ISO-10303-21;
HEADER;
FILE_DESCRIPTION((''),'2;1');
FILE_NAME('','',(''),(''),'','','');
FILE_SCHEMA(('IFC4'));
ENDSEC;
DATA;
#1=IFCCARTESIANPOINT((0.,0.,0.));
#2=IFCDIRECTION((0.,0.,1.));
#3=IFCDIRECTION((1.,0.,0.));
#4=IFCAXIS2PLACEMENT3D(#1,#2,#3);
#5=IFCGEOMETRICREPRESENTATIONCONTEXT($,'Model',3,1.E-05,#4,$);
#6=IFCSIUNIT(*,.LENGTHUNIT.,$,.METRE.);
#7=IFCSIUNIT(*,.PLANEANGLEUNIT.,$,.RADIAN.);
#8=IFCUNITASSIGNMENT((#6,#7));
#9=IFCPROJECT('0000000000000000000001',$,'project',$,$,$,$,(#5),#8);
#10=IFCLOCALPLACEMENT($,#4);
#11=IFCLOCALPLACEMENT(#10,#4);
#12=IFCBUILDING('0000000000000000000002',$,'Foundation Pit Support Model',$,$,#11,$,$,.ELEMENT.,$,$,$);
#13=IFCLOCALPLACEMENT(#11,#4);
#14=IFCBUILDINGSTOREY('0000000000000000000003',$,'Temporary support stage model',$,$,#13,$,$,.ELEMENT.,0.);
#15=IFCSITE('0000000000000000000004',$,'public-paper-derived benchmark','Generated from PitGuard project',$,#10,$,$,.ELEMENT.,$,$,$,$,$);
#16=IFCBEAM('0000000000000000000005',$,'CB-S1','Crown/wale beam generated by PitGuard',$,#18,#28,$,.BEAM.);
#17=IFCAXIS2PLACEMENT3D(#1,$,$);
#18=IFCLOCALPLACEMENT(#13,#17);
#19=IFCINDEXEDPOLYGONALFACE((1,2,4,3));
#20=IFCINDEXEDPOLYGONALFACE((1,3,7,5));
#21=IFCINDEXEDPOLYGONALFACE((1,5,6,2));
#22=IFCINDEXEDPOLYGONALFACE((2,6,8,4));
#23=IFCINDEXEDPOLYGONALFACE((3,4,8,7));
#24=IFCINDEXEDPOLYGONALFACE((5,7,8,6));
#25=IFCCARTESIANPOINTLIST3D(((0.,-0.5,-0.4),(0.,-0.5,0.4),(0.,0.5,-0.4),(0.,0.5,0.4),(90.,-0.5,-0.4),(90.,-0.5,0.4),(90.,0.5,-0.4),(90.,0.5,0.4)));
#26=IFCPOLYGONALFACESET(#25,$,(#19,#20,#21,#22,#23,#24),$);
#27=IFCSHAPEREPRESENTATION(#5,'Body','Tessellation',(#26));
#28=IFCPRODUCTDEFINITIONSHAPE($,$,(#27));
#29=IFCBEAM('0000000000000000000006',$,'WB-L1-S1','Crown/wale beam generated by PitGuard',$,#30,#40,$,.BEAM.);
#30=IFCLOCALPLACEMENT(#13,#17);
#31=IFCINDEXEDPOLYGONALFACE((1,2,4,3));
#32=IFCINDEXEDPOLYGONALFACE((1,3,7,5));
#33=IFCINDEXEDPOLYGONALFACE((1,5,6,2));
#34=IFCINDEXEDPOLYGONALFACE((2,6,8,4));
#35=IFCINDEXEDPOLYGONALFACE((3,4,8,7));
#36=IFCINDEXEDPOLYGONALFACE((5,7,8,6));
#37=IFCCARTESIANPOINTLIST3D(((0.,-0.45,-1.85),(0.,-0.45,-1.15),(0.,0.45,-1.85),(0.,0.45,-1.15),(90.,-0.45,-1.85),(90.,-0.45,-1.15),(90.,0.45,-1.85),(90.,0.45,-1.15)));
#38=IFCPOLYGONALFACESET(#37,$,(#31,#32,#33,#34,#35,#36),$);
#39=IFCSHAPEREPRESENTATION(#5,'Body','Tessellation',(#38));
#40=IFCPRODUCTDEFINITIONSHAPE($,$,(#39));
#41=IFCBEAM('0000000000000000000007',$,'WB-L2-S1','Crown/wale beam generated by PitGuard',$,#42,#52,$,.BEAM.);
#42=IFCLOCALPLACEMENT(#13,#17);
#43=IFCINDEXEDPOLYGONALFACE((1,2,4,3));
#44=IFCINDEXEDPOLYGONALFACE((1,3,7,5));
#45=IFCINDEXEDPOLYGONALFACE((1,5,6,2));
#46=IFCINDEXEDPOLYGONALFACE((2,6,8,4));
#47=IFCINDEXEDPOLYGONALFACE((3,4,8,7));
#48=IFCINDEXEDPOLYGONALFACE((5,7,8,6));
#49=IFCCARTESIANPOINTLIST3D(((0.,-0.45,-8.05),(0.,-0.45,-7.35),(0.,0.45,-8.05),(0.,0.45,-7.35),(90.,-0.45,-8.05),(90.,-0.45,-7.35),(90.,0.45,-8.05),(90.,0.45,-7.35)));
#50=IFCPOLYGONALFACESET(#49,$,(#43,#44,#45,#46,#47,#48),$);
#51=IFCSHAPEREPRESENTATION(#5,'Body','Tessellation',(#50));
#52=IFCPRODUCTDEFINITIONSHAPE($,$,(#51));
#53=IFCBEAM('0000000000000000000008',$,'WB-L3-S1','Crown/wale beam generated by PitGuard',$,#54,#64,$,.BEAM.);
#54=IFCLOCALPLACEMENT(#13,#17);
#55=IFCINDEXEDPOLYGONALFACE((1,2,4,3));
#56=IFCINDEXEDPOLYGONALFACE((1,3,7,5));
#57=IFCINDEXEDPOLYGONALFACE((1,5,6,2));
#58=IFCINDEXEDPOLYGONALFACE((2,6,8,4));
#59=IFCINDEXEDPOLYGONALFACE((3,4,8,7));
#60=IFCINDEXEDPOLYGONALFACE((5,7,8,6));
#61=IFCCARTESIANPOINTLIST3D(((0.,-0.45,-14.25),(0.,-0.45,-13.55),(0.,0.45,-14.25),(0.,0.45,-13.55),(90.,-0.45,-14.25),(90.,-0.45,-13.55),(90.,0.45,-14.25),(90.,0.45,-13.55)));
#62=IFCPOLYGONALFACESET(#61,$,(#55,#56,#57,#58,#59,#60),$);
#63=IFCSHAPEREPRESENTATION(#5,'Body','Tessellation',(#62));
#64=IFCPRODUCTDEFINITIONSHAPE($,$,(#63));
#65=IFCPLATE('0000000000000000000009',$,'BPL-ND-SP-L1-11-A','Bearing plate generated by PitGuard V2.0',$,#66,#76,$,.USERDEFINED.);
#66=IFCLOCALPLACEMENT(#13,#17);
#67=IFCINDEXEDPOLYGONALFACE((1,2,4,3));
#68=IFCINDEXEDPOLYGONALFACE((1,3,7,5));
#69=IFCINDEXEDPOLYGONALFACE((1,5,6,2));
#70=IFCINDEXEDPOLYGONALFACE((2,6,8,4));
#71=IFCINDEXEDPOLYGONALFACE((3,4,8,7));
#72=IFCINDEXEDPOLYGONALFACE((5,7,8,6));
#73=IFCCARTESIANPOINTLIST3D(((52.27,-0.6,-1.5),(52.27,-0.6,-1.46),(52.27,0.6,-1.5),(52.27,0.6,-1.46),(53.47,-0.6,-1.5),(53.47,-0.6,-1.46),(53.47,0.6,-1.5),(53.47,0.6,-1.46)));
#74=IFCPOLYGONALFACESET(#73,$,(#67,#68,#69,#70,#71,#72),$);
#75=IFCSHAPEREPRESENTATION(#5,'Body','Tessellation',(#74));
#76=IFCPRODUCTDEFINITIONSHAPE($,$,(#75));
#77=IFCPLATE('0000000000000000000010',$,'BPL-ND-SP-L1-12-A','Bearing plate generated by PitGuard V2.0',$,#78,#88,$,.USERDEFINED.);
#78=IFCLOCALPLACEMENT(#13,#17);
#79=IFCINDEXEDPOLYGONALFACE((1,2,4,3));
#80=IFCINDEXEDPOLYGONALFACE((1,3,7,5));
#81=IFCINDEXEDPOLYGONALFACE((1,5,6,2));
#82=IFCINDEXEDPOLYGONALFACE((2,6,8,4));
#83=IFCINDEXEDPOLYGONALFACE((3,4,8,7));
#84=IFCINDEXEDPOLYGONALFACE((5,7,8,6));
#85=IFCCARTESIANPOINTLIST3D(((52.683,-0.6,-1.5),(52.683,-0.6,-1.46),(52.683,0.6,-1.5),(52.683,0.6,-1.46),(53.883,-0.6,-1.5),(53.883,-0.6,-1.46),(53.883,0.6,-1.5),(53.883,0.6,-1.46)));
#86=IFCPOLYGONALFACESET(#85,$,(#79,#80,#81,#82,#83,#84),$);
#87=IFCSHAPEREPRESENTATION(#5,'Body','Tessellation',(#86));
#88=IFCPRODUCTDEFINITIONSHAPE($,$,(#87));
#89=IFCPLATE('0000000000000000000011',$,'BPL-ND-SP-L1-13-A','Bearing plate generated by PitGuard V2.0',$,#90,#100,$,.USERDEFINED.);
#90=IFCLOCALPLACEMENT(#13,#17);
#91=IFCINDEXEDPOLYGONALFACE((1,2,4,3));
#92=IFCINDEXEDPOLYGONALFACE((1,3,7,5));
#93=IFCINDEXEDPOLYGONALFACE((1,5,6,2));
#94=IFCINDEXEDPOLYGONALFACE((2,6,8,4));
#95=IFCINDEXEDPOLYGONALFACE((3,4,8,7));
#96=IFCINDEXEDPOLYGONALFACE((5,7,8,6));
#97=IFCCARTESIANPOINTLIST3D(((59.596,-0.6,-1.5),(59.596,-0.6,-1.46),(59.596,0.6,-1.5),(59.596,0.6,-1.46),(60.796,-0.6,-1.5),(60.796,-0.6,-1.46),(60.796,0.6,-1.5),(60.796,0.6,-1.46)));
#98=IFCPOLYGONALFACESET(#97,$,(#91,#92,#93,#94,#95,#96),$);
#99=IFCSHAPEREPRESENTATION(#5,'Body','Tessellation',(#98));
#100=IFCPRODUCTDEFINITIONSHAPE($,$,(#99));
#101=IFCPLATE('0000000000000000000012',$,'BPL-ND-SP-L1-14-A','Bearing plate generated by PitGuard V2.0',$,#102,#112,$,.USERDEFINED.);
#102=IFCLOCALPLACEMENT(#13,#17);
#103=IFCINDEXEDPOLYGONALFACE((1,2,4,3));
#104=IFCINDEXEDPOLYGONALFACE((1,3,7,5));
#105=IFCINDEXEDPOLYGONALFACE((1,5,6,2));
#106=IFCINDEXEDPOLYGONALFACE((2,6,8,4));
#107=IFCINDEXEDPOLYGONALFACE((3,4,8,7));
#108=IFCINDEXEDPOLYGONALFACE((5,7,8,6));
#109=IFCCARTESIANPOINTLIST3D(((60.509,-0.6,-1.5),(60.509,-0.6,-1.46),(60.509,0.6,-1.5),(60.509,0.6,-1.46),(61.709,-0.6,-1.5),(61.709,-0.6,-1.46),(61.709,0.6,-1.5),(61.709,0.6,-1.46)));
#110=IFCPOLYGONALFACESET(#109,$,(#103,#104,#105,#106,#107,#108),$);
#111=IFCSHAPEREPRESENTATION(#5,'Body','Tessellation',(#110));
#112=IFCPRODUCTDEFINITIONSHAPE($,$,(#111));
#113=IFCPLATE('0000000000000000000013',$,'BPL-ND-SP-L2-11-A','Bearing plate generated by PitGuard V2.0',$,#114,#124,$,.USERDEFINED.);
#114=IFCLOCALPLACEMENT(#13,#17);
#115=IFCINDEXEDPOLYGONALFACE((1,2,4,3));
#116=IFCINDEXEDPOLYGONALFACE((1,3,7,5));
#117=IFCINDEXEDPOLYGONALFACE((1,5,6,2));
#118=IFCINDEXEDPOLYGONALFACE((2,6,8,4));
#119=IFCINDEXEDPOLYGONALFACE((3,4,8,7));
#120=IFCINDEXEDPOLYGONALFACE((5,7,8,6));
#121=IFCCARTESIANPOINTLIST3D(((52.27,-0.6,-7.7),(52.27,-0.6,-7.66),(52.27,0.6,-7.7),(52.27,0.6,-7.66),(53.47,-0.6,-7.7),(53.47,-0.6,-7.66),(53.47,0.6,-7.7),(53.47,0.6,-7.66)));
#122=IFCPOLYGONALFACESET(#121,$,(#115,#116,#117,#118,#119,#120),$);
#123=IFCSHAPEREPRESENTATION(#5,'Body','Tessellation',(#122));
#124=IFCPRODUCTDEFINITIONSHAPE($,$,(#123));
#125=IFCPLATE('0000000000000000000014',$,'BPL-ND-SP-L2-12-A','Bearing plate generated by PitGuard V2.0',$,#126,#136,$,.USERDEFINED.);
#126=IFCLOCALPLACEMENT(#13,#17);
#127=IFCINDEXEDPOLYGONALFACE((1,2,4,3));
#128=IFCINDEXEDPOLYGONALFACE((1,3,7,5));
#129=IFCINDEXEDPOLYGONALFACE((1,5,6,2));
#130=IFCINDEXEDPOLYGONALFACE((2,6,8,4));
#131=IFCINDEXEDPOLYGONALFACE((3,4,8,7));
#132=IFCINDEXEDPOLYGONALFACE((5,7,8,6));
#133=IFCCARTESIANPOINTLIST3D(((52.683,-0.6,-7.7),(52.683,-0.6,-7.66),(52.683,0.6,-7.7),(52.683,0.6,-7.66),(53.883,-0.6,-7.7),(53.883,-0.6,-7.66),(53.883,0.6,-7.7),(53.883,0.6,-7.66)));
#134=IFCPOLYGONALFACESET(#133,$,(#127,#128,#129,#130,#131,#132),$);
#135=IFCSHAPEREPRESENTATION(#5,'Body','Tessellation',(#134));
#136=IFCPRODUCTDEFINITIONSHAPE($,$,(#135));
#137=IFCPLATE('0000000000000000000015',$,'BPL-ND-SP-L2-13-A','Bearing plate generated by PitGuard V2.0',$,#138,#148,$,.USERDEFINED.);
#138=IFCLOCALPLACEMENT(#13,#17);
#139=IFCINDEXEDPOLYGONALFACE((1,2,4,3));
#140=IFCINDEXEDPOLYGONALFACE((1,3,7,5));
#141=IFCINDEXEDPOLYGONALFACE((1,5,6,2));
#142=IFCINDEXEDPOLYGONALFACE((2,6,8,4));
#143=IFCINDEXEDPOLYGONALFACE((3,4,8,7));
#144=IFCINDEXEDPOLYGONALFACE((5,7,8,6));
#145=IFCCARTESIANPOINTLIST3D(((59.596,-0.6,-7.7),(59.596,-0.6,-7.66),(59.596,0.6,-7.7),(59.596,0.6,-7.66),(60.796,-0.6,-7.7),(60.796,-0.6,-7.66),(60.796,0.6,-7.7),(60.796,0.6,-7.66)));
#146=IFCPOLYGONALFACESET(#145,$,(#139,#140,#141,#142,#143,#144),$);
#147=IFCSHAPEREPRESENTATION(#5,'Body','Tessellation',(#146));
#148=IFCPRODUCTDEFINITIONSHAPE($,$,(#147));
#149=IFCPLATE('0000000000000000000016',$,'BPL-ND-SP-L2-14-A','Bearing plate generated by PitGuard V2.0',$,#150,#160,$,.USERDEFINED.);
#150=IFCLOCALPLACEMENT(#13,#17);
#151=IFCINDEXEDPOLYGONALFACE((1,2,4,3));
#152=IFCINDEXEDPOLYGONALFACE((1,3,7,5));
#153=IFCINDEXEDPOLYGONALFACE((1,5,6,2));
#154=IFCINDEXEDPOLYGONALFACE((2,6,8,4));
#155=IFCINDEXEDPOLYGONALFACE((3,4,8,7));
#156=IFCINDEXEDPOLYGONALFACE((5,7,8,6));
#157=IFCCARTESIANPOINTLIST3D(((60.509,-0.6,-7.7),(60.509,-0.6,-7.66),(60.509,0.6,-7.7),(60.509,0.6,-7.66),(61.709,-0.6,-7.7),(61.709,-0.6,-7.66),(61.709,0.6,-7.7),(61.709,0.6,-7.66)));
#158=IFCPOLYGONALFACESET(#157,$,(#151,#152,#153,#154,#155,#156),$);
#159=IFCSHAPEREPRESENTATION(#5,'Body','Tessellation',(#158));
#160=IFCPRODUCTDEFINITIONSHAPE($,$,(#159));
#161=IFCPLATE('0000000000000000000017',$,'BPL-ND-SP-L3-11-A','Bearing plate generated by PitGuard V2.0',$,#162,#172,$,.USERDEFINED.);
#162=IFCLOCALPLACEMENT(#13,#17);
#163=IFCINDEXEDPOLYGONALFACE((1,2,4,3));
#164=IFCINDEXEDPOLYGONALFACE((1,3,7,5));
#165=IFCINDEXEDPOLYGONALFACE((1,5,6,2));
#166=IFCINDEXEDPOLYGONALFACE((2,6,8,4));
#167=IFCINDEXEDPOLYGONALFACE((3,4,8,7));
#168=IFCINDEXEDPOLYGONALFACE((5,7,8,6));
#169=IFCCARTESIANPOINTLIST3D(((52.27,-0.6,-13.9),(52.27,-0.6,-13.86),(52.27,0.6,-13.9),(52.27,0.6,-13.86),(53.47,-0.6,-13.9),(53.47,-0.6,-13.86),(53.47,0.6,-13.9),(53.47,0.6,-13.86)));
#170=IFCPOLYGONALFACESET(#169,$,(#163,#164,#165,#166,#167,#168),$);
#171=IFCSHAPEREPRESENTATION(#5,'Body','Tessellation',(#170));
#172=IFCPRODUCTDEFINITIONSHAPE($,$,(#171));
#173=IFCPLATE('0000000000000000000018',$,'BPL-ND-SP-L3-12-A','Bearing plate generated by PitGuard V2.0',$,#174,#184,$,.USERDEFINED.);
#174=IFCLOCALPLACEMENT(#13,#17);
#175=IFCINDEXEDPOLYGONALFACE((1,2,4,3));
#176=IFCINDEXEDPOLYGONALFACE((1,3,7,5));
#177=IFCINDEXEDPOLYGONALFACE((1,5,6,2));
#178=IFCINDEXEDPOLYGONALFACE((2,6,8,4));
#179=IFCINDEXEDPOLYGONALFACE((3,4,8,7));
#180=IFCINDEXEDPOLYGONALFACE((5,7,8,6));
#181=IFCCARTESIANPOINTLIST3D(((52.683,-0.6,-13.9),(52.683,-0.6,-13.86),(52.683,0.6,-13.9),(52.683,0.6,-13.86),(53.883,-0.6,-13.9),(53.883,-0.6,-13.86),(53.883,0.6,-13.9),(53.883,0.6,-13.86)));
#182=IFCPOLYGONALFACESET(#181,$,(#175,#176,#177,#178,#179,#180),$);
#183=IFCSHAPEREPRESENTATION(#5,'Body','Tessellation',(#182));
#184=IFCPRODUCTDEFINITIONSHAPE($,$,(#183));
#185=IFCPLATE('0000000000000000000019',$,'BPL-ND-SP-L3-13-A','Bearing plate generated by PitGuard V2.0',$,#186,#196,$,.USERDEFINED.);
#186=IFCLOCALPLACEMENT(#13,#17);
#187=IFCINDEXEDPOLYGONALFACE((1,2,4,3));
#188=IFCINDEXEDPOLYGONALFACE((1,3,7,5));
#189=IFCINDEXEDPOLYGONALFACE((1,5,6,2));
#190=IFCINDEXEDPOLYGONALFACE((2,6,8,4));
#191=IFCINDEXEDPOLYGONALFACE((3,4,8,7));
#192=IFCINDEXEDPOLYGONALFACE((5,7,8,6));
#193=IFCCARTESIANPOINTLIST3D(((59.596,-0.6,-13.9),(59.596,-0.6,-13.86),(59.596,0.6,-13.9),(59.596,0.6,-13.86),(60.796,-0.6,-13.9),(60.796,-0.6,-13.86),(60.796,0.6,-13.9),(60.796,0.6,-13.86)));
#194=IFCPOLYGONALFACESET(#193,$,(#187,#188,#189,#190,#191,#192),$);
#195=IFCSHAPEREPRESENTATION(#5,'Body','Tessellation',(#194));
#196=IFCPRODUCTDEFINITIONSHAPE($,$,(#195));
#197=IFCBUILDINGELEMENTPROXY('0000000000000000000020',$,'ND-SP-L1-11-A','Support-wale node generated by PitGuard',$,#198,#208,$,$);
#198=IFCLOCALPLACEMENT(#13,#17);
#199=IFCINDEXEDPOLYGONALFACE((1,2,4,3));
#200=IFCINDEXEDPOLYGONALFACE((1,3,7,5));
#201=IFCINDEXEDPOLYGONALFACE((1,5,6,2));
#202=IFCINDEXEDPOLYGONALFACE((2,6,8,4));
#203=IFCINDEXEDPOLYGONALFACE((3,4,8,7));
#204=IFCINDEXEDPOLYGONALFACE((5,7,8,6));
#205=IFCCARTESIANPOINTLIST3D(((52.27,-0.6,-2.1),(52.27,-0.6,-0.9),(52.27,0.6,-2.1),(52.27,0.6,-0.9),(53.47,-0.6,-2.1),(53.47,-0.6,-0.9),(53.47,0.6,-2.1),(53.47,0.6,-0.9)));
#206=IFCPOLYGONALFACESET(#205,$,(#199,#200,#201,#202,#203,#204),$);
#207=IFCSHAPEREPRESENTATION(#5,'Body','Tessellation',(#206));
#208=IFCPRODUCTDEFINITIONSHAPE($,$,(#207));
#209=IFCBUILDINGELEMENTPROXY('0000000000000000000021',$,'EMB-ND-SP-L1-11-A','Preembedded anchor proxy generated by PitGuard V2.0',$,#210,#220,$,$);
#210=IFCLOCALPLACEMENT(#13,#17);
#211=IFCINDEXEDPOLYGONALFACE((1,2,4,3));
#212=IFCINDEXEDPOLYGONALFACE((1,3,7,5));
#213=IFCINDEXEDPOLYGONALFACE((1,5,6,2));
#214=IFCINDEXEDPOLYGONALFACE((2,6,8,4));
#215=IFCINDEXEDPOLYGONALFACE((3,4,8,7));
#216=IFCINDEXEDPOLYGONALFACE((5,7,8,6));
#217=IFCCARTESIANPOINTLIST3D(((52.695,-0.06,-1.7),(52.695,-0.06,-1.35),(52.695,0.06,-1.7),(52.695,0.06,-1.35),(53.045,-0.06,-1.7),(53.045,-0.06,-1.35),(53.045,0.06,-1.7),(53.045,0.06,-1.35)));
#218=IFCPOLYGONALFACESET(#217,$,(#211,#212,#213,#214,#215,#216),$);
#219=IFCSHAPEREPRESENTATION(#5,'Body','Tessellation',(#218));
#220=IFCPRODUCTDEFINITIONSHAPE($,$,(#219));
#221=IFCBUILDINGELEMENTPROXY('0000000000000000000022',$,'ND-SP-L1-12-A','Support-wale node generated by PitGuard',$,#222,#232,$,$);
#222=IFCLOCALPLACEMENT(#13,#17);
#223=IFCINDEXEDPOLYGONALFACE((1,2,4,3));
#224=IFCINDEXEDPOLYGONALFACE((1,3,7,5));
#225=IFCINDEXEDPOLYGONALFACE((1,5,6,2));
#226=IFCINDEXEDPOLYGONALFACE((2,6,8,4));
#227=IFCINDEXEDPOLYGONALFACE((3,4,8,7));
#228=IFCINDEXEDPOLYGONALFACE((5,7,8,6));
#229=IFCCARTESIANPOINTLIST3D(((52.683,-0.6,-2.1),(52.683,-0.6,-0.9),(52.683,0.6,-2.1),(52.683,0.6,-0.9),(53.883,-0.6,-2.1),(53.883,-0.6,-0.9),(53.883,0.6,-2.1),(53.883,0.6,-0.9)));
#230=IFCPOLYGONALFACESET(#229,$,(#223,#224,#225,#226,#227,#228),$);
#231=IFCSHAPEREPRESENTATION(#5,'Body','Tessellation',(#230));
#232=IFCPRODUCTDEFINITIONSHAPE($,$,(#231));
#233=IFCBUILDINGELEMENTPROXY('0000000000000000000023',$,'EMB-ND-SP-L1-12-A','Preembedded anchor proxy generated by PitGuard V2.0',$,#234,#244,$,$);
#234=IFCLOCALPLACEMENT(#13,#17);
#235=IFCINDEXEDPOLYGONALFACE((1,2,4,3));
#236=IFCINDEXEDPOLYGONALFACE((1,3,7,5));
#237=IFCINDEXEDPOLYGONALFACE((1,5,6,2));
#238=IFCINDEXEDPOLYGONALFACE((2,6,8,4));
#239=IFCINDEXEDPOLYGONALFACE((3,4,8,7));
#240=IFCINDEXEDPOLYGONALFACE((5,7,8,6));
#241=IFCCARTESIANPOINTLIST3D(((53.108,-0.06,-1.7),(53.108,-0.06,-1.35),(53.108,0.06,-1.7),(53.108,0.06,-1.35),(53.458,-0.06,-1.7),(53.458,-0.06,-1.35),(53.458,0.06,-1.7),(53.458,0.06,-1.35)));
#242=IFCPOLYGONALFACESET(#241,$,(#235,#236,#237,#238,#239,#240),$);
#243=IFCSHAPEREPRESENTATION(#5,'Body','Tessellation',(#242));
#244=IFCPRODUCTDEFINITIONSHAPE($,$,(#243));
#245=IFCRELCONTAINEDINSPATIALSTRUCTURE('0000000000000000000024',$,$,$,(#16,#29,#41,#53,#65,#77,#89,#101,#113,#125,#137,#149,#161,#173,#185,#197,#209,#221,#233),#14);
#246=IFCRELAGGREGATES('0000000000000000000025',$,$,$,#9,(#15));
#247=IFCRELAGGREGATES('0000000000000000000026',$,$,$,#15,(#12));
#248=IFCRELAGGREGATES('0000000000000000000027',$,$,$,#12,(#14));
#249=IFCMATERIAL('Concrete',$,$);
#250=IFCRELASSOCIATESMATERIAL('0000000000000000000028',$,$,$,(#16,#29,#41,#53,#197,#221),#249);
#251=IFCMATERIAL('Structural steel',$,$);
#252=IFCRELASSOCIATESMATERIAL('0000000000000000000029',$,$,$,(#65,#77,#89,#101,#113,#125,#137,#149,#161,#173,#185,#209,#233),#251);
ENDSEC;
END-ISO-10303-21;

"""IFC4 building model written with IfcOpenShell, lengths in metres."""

from ifc_helpers import new_model, si_unit, frame, origin_with_axes, origin_2d, place, context, project, spatial, rectangle, extrude, material, element, save


model = new_model("IFC4")

# Units and contexts
model_context = context("Model", 3, precision=1e-05, world=origin_with_axes())
ifc_project = project(units=[si_unit("LENGTHUNIT", "METRE"), si_unit("PLANEANGLEUNIT", "RADIAN")], contexts=[model_context])

# Site, building, storey
site_placement = place(None, origin_with_axes())
site = spatial("IfcSite", under=ifc_project, at=site_placement, Name="public-paper-derived benchmark", Description="Generated from PitGuard project", CompositionType="ELEMENT")
building_placement = place(site_placement, origin_with_axes())
building = spatial("IfcBuilding", under=site, at=building_placement, Name="Foundation Pit Support Model", CompositionType="ELEMENT")
storey_placement = place(building_placement, origin_with_axes())
storey = spatial("IfcBuildingStorey", under=building, at=storey_placement, Name="Temporary support stage model", CompositionType="ELEMENT", Elevation=0.0)

# Beams
ifc_material_1 = material(Name="Concrete")
beam_placement = place(storey_placement, frame((45.0, 0.0, -0.4), z_axis=(0.0, 0.0, 1.0), x_axis=(1.0, 0.0, 0.0)))
element("IfcBeam", 1, at=beam_placement, inside=storey, material=ifc_material_1, Name="CB-S1", Description="Crown/wale beam generated by PitGuard", PredefinedType="BEAM", context=model_context, shape_type="SweptSolid", body=[
    extrude(rectangle(XDim=90.0, YDim=1.0, at=origin_2d()), origin_with_axes(), (0.0, 0.0, 1.0), 0.8),
])
for number, where, z_axis, x_axis, name in (
    (2, (45.0, 0.0, -1.85), (0.0, 0.0, 1.0), (1.0, 0.0, 0.0), "WB-L1-S1"),
    (3, (45.0, 0.0, -8.05), (0.0, 0.0, 1.0), (1.0, 0.0, 0.0), "WB-L2-S1"),
    (4, (45.0, 0.0, -14.25), (0.0, 0.0, 1.0), (1.0, 0.0, 0.0), "WB-L3-S1"),
):
    element("IfcBeam", number, at=place(storey_placement, frame(where, z_axis=z_axis, x_axis=x_axis)), inside=storey, material=ifc_material_1, Name=name, Description="Crown/wale beam generated by PitGuard", PredefinedType="BEAM", context=model_context, shape_type="SweptSolid", body=[
        extrude(rectangle(XDim=90.0, YDim=0.9, at=origin_2d()), origin_with_axes(), (0.0, 0.0, 1.0), 0.7),
    ])

# Plates
ifc_material_2 = material(Name="Structural steel")
for number, where, z_axis, x_axis, name in (
    (5, (52.87, 0.0, -1.5), (0.0, 0.0, 1.0), (1.0, 0.0, 0.0), "BPL-ND-SP-L1-11-A"),
    (6, (53.283, 0.0, -1.5), (0.0, 0.0, 1.0), (1.0, 0.0, 0.0), "BPL-ND-SP-L1-12-A"),
    (7, (60.196, 0.0, -1.5), (0.0, 0.0, 1.0), (1.0, 0.0, 0.0), "BPL-ND-SP-L1-13-A"),
    (8, (61.109, 0.0, -1.5), (0.0, 0.0, 1.0), (1.0, 0.0, 0.0), "BPL-ND-SP-L1-14-A"),
    (9, (52.87, 0.0, -7.7), (0.0, 0.0, 1.0), (1.0, 0.0, 0.0), "BPL-ND-SP-L2-11-A"),
    (10, (53.283, 0.0, -7.7), (0.0, 0.0, 1.0), (1.0, 0.0, 0.0), "BPL-ND-SP-L2-12-A"),
    (11, (60.196, 0.0, -7.7), (0.0, 0.0, 1.0), (1.0, 0.0, 0.0), "BPL-ND-SP-L2-13-A"),
    (12, (61.109, 0.0, -7.7), (0.0, 0.0, 1.0), (1.0, 0.0, 0.0), "BPL-ND-SP-L2-14-A"),
    (13, (52.87, 0.0, -13.9), (0.0, 0.0, 1.0), (1.0, 0.0, 0.0), "BPL-ND-SP-L3-11-A"),
    (14, (53.283, 0.0, -13.9), (0.0, 0.0, 1.0), (1.0, 0.0, 0.0), "BPL-ND-SP-L3-12-A"),
    (15, (60.196, 0.0, -13.9), (0.0, 0.0, 1.0), (1.0, 0.0, 0.0), "BPL-ND-SP-L3-13-A"),
):
    element("IfcPlate", number, at=place(storey_placement, frame(where, z_axis=z_axis, x_axis=x_axis)), inside=storey, material=ifc_material_2, Name=name, Description="Bearing plate generated by PitGuard V2.0", PredefinedType="USERDEFINED", context=model_context, shape_type="SweptSolid", body=[
        extrude(rectangle(XDim=1.2, YDim=1.2, at=origin_2d()), origin_with_axes(), (0.0, 0.0, 1.0), 0.04),
    ])

# Building element proxies
proxy_1_placement = place(storey_placement, frame((52.87, 0.0, -2.1), z_axis=(0.0, 0.0, 1.0), x_axis=(1.0, 0.0, 0.0)))
element("IfcBuildingElementProxy", 16, at=proxy_1_placement, inside=storey, material=ifc_material_1, Name="ND-SP-L1-11-A", Description="Support-wale node generated by PitGuard", context=model_context, shape_type="SweptSolid", body=[
    extrude(rectangle(XDim=1.2, YDim=1.2, at=origin_2d()), origin_with_axes(), (0.0, 0.0, 1.0), 1.2),
])
proxy_2_placement = place(storey_placement, frame((52.87, 0.0, -1.7), z_axis=(0.0, 0.0, 1.0), x_axis=(1.0, 0.0, 0.0)))
element("IfcBuildingElementProxy", 17, at=proxy_2_placement, inside=storey, material=ifc_material_2, Name="EMB-ND-SP-L1-11-A", Description="Preembedded anchor proxy generated by PitGuard V2.0", context=model_context, shape_type="SweptSolid", body=[
    extrude(rectangle(XDim=0.35, YDim=0.12, at=origin_2d()), origin_with_axes(), (0.0, 0.0, 1.0), 0.35),
])
proxy_3_placement = place(storey_placement, frame((53.283, 0.0, -2.1), z_axis=(0.0, 0.0, 1.0), x_axis=(1.0, 0.0, 0.0)))
element("IfcBuildingElementProxy", 18, at=proxy_3_placement, inside=storey, material=ifc_material_1, Name="ND-SP-L1-12-A", Description="Support-wale node generated by PitGuard", context=model_context, shape_type="SweptSolid", body=[
    extrude(rectangle(XDim=1.2, YDim=1.2, at=origin_2d()), origin_with_axes(), (0.0, 0.0, 1.0), 1.2),
])
proxy_4_placement = place(storey_placement, frame((53.283, 0.0, -1.7), z_axis=(0.0, 0.0, 1.0), x_axis=(1.0, 0.0, 0.0)))
element("IfcBuildingElementProxy", 19, at=proxy_4_placement, inside=storey, material=ifc_material_2, Name="EMB-ND-SP-L1-12-A", Description="Preembedded anchor proxy generated by PitGuard V2.0", context=model_context, shape_type="SweptSolid", body=[
    extrude(rectangle(XDim=0.35, YDim=0.12, at=origin_2d()), origin_with_axes(), (0.0, 0.0, 1.0), 0.35),
])

save(model, "model.ifc")
